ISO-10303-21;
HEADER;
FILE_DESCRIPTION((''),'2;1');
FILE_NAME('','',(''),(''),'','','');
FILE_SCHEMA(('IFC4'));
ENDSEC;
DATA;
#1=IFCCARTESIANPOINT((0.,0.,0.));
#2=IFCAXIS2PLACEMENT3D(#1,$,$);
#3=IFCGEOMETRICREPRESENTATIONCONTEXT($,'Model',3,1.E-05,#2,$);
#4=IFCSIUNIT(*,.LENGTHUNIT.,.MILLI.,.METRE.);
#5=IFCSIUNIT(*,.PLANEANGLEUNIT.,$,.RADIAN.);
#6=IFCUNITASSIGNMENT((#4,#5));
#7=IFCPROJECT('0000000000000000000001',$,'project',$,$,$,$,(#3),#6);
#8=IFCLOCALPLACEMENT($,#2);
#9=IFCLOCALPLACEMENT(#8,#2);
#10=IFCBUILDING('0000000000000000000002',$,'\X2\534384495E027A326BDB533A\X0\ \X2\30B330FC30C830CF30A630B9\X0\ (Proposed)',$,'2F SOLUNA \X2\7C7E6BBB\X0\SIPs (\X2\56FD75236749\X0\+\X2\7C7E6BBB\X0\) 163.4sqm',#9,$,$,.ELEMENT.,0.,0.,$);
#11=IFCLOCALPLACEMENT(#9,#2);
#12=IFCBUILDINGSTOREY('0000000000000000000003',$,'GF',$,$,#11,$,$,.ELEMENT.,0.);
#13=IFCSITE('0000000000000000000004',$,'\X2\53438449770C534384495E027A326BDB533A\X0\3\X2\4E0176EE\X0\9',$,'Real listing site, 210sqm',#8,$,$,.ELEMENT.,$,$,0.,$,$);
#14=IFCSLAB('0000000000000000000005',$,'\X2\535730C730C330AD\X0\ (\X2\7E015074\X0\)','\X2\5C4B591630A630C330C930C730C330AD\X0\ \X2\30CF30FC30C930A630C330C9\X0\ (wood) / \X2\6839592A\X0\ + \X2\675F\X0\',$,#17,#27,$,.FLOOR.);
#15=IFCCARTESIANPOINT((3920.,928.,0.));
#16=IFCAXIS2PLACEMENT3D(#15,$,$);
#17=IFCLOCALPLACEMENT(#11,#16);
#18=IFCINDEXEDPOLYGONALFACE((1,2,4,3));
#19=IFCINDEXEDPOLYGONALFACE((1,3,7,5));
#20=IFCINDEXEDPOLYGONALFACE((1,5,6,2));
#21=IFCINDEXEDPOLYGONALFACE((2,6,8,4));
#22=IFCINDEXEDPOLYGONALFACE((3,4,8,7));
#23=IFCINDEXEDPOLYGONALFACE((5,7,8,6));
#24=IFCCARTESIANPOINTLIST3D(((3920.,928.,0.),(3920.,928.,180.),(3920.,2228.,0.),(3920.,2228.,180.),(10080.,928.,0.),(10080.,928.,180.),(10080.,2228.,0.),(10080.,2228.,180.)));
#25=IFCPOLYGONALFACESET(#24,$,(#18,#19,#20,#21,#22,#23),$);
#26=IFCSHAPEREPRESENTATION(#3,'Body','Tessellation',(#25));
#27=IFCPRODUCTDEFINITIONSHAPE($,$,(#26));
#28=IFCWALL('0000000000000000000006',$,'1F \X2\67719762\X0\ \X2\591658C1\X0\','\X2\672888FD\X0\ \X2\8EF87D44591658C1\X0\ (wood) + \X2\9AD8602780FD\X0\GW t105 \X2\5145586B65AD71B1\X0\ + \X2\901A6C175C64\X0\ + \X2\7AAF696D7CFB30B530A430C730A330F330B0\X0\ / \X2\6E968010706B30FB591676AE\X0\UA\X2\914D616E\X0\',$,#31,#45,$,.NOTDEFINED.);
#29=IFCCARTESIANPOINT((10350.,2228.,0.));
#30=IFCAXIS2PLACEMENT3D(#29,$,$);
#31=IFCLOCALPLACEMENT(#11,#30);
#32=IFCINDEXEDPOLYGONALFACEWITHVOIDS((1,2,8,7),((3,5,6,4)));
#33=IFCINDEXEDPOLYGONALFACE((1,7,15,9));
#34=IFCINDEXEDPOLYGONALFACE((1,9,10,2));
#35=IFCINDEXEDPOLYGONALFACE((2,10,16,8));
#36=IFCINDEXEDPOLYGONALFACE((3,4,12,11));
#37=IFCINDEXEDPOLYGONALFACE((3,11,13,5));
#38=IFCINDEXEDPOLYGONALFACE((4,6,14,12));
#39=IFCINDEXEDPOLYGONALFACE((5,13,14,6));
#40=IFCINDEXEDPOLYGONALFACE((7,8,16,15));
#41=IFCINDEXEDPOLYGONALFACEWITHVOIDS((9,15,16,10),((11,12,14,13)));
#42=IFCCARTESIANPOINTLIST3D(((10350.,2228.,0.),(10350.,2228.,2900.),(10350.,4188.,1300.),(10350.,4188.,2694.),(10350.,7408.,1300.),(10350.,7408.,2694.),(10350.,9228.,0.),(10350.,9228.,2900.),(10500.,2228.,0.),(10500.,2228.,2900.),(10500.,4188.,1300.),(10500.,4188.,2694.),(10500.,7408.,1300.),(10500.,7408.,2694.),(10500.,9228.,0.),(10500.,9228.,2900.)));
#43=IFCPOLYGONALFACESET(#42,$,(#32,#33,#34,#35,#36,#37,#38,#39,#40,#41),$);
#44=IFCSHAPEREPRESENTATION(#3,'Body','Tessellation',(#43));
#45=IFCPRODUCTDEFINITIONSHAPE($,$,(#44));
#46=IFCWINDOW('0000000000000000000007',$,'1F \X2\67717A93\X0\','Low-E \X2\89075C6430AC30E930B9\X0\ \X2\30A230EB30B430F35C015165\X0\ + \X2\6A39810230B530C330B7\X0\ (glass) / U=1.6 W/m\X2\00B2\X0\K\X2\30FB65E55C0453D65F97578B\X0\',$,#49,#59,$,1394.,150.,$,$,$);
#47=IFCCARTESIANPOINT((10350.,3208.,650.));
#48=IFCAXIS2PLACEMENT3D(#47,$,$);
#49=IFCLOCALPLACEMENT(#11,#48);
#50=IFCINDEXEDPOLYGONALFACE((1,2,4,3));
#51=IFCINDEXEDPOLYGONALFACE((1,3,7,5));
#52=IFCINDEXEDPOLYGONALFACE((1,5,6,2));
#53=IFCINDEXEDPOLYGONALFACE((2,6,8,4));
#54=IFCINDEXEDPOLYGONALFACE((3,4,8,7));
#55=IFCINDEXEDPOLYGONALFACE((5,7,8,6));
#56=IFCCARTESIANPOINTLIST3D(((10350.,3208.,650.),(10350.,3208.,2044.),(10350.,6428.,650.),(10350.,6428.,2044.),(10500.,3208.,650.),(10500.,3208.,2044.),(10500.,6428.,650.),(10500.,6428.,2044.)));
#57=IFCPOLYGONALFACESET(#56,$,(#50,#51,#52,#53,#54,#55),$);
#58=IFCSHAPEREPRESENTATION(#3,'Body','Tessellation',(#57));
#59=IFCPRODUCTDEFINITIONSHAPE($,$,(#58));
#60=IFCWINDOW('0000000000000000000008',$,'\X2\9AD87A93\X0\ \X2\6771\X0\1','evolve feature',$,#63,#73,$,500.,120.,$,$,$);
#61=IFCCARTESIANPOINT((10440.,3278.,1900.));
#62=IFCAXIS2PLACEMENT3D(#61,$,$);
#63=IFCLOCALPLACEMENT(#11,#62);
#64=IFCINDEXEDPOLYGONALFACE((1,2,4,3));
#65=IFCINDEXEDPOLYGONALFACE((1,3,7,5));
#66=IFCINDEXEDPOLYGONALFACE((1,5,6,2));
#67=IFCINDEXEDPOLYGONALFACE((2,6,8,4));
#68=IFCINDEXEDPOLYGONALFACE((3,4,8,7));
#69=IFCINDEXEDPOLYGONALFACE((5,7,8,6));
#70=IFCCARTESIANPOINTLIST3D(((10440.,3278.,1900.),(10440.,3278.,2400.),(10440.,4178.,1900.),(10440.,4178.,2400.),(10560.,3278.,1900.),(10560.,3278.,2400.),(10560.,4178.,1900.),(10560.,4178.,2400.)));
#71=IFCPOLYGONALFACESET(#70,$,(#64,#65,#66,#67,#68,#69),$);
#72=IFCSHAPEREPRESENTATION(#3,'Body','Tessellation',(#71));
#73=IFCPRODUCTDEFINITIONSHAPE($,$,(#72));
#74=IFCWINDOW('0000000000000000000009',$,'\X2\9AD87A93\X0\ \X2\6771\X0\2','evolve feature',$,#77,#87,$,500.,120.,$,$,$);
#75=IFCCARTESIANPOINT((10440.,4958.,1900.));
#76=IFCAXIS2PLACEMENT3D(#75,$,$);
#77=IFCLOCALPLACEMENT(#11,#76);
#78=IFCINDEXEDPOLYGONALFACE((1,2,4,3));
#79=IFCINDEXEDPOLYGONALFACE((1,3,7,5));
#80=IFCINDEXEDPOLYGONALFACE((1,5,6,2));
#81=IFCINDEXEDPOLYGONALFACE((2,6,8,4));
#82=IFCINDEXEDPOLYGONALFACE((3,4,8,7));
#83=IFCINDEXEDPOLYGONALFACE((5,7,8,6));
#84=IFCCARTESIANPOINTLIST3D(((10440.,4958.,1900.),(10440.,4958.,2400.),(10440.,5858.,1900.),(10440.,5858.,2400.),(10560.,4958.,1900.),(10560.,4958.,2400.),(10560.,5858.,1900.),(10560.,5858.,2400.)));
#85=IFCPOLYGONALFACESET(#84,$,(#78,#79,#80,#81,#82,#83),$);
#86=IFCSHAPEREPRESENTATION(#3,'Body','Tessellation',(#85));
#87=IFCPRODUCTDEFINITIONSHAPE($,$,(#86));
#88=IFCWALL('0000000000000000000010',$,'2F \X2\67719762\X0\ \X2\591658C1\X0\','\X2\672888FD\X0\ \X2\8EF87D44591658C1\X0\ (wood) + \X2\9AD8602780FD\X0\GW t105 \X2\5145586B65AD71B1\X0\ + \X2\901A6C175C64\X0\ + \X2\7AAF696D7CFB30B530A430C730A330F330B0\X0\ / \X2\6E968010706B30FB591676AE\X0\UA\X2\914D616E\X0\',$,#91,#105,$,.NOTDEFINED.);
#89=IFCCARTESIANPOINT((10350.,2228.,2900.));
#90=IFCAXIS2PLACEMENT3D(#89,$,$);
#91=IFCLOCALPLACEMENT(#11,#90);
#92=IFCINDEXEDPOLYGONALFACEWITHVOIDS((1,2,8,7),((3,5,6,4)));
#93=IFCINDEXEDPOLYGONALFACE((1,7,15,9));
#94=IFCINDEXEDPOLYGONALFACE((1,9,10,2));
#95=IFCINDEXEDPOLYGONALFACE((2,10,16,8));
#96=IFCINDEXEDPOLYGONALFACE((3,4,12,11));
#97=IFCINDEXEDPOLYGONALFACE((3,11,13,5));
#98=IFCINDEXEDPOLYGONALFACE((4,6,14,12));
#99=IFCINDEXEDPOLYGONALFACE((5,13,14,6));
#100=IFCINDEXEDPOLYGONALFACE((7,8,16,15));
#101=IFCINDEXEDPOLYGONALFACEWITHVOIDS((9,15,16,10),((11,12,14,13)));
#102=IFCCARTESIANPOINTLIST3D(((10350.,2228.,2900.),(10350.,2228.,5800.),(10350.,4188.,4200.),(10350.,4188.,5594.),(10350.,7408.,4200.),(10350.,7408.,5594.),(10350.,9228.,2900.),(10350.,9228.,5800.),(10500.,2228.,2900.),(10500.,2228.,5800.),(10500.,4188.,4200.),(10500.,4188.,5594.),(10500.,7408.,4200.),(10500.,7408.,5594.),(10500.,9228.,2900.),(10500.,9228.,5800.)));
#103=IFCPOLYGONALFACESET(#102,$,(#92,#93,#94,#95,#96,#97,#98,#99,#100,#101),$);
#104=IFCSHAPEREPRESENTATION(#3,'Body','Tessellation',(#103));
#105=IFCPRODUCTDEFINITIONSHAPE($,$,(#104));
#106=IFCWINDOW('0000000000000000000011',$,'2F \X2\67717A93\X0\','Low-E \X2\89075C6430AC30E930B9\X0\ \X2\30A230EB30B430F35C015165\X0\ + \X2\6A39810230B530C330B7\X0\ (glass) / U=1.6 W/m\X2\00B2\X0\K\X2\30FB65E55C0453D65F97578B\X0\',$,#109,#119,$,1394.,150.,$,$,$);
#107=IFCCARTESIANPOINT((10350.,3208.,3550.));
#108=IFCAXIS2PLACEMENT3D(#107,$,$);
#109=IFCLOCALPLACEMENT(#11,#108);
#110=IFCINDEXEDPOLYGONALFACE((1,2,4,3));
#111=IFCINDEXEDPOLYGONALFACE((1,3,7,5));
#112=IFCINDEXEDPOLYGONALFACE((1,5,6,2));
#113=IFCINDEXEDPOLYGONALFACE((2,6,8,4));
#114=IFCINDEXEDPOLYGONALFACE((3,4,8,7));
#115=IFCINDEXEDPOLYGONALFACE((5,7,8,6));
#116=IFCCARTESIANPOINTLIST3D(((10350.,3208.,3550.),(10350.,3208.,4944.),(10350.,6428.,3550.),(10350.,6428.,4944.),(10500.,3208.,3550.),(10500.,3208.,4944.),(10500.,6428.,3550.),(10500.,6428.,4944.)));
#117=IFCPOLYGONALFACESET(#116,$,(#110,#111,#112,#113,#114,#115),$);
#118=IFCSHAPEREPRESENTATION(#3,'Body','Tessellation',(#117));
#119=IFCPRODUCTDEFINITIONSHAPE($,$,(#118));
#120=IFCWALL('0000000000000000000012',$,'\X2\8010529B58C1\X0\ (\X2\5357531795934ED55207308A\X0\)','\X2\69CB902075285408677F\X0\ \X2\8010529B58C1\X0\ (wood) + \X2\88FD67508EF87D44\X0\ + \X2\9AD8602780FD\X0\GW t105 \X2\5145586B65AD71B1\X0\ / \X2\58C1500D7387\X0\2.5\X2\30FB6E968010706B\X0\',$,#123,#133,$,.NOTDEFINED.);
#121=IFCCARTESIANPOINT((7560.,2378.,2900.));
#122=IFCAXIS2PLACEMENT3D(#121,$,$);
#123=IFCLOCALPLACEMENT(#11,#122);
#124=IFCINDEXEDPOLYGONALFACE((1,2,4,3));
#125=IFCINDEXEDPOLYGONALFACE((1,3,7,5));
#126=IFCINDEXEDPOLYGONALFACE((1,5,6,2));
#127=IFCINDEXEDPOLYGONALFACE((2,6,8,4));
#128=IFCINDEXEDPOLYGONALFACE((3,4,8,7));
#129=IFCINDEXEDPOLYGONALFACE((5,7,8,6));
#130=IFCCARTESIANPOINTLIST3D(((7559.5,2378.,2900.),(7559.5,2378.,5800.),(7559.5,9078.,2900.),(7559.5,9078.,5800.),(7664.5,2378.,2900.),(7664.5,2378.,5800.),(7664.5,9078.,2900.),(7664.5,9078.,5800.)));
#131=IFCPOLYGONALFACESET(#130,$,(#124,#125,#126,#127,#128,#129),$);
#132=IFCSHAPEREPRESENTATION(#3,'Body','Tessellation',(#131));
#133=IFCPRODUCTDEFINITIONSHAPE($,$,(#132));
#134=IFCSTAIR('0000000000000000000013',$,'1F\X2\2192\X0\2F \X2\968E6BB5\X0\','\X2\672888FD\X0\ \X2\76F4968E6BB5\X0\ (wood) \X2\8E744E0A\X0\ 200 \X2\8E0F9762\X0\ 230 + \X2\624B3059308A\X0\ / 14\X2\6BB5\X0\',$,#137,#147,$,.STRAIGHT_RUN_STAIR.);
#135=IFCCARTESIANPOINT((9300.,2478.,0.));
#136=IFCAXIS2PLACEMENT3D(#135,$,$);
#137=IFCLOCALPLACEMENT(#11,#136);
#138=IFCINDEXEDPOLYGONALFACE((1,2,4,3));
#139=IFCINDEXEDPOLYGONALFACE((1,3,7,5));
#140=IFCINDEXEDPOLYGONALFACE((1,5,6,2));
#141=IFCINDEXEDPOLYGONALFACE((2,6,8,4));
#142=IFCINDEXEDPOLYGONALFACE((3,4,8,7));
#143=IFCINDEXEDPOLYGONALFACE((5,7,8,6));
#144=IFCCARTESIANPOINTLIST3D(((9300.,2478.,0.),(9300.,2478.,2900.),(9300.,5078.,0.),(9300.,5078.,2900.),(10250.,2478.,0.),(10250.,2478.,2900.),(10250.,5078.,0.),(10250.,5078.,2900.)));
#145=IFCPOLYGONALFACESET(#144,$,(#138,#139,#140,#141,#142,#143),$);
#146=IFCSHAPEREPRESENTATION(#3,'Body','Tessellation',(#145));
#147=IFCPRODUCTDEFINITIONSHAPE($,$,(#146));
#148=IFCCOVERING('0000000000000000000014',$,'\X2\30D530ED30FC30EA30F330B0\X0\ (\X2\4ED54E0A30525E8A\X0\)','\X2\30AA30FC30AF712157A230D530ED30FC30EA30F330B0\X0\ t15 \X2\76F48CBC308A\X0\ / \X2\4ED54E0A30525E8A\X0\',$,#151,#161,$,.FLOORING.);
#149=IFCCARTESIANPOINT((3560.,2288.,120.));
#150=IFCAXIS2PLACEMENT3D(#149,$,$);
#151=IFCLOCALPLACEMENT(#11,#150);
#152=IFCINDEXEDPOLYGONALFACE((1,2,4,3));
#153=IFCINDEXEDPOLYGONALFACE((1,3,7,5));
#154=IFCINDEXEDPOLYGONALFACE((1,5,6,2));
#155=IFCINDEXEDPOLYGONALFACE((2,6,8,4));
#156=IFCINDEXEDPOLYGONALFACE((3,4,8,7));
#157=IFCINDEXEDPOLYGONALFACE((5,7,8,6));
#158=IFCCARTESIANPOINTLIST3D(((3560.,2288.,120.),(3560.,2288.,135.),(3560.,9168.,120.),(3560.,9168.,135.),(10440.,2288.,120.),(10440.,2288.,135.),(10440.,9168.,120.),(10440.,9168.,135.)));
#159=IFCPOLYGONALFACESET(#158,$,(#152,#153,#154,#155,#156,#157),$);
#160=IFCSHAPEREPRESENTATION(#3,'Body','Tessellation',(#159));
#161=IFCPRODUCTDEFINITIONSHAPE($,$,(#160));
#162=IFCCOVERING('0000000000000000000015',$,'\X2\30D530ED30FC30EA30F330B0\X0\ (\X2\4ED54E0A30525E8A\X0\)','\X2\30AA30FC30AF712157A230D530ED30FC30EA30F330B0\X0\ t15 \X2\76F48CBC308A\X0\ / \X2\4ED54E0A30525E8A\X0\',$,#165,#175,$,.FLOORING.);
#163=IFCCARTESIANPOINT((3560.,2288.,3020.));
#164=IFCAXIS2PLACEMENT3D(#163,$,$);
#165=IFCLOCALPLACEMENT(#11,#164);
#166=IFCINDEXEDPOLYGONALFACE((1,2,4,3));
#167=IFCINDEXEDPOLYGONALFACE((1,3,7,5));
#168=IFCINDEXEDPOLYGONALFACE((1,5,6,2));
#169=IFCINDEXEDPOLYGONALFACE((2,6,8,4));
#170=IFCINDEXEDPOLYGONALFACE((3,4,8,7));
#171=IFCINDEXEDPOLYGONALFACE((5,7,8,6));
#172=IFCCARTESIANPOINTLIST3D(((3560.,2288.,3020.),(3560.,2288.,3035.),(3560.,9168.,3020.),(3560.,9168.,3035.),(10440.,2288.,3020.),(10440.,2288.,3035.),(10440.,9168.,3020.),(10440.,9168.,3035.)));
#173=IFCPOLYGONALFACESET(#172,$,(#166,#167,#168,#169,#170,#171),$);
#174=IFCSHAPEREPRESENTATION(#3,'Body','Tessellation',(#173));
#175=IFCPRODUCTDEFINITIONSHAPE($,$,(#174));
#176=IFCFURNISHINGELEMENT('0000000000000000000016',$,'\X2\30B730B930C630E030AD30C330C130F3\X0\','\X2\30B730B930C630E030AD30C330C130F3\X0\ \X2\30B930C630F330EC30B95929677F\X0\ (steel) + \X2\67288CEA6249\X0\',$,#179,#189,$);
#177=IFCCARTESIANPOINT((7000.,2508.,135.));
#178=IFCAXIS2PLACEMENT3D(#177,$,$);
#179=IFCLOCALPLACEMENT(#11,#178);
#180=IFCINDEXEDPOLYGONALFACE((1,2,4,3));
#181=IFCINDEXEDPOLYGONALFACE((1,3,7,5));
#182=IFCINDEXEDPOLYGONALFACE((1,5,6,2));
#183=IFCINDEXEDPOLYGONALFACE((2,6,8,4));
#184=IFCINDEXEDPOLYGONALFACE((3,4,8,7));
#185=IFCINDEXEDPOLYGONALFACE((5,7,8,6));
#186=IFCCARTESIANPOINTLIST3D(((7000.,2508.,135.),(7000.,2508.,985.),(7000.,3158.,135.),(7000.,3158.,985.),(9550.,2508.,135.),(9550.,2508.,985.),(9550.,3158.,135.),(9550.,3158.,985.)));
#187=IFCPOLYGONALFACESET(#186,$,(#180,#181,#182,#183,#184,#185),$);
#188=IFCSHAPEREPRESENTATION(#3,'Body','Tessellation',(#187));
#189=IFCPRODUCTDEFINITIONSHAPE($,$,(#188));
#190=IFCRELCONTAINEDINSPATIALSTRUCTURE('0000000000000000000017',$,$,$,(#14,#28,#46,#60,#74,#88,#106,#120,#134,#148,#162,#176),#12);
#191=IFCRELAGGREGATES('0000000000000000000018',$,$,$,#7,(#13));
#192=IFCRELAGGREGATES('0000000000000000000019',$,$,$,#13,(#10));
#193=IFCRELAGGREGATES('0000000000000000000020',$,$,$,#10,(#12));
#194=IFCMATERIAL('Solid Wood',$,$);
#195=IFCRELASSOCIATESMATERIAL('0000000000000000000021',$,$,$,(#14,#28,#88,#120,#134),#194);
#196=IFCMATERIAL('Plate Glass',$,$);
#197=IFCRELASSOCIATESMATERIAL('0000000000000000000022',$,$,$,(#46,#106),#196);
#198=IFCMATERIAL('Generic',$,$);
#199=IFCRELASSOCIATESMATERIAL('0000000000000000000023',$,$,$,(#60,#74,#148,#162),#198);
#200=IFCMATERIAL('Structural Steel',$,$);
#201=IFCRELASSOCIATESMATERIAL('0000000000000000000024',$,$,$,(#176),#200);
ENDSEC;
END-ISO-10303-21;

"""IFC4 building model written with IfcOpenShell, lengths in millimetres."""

from ifc_helpers import new_model, si_unit, frame, frame_2d, origin, place, context, project, spatial, rectangle, extrude, material, element, fill, save


model = new_model("IFC4")

# Units and contexts
model_context = context("Model", 3, precision=1e-05, world=origin())
ifc_project = project(units=[si_unit("LENGTHUNIT", "METRE", prefix="MILLI"), si_unit("PLANEANGLEUNIT", "RADIAN")], contexts=[model_context])

# Site, building, storey
site_placement = place(None, origin())
site = spatial("IfcSite", under=ifc_project, at=site_placement, Name="千葉県千葉市稲毛区3丁目9", ObjectType="Real listing site, 210sqm", CompositionType="ELEMENT", RefElevation=0.0)
building_placement = place(site_placement, origin())
building = spatial("IfcBuilding", under=site, at=building_placement, Name="千葉市稲毛区 コートハウス (Proposed)", ObjectType="2F SOLUNA 籾殻SIPs (国産杉+籾殻) 163.4sqm", CompositionType="ELEMENT", ElevationOfRefHeight=0.0, ElevationOfTerrain=0.0)
storey_placement = place(building_placement, origin())
storey = spatial("IfcBuildingStorey", under=building, at=storey_placement, Name="GF", CompositionType="ELEMENT", Elevation=0.0)

# Slab
ifc_material_1 = material(Name="Solid Wood")
slab_placement = place(storey_placement, frame((3920.0, 928.0, 0.0)))
element("IfcSlab", 1, at=slab_placement, inside=storey, material=ifc_material_1, Name="南デッキ (縁側)", Description="屋外ウッドデッキ ハードウッド (wood) / 根太 + 束", PredefinedType="FLOOR", context=model_context, shape_type="SweptSolid", body=[
    extrude(rectangle(XDim=6160.0, YDim=1300.0, at=frame_2d((3080.0, 650.0))), frame((3920.0, 928.0, 0.0)), (0.0, 0.0, 1.0), 180.0),
])

# Wall, openings, windows
wall_1_placement = place(storey_placement, frame((10350.0, 2228.0, 0.0)))
wall_1 = element("IfcWall", 2, at=wall_1_placement, inside=storey, material=ifc_material_1, Name="1F 東面 外壁", Description="木製 軸組外壁 (wood) + 高性能GW t105 充填断熱 + 通気層 + 窯業系サイディング / 準耐火・外皮UA配慮", PredefinedType="NOTDEFINED", context=model_context, shape_type="SweptSolid", body=[
    extrude(rectangle(XDim=150.0, YDim=7000.0, at=frame_2d((75.0, 3500.0))), frame((10350.0, 2228.0, 0.0)), (0.0, 0.0, 1.0), 2900.0),
])
opening_1_placement = place(storey_placement, frame((10350.0, 3208.0, 650.0)))
opening_1 = element("IfcOpeningElement", 3, at=opening_1_placement, cuts=wall_1, PredefinedType="NOTDEFINED", context=model_context, shape_type="SweptSolid", body=[
    extrude(rectangle(XDim=150.0, YDim=3220.0, at=frame_2d((75.0, 1610.0))), frame((10350.0, 3208.0, 650.0)), (0.0, 0.0, 1.0), 1394.0),
])
opening_2_placement = place(storey_placement, frame((10440.0, 3278.0, 1900.0)))
opening_2 = element("IfcOpeningElement", 4, at=opening_2_placement, cuts=wall_1, PredefinedType="NOTDEFINED", context=model_context, shape_type="SweptSolid", body=[
    extrude(rectangle(XDim=120.0, YDim=900.0, at=frame_2d((60.0, 450.0))), frame((10440.0, 3278.0, 1900.0)), (0.0, 0.0, 1.0), 500.0),
])
opening_3_placement = place(storey_placement, frame((10440.0, 4958.0, 1900.0)))
opening_3 = element("IfcOpeningElement", 5, at=opening_3_placement, cuts=wall_1, PredefinedType="NOTDEFINED", context=model_context, shape_type="SweptSolid", body=[
    extrude(rectangle(XDim=120.0, YDim=900.0, at=frame_2d((60.0, 450.0))), frame((10440.0, 4958.0, 1900.0)), (0.0, 0.0, 1.0), 500.0),
])
ifc_material_2 = material(Name="Plate Glass")
window_1_placement = place(storey_placement, frame((10350.0, 3208.0, 650.0)))
window_1 = element("IfcWindow", 6, at=window_1_placement, inside=storey, material=ifc_material_2, Name="1F 東窓", Description="Low-E 複層ガラス アルゴン封入 + 樹脂サッシ (glass) / U=1.6 W/m²K・日射取得型", OverallHeight=1394.0, OverallWidth=150.0, context=model_context, shape_type="SweptSolid", body=[
    extrude(rectangle(XDim=150.0, YDim=3220.0, at=frame_2d((75.0, 1610.0))), frame((10350.0, 3208.0, 650.0)), (0.0, 0.0, 1.0), 1394.0),
])
fill(opening_1, window_1)
ifc_material_3 = material(Name="Generic")
window_2_placement = place(storey_placement, frame((10440.0, 3278.0, 1900.0)))
window_2 = element("IfcWindow", 7, at=window_2_placement, inside=storey, material=ifc_material_3, Name="高窓 東1", Description="evolve feature", OverallHeight=500.0, OverallWidth=120.0, context=model_context, shape_type="SweptSolid", body=[
    extrude(rectangle(XDim=120.0, YDim=900.0, at=frame_2d((60.0, 450.0))), frame((10440.0, 3278.0, 1900.0)), (0.0, 0.0, 1.0), 500.0),
])
fill(opening_2, window_2)
window_3_placement = place(storey_placement, frame((10440.0, 4958.0, 1900.0)))
window_3 = element("IfcWindow", 8, at=window_3_placement, inside=storey, material=ifc_material_3, Name="高窓 東2", Description="evolve feature", OverallHeight=500.0, OverallWidth=120.0, context=model_context, shape_type="SweptSolid", body=[
    extrude(rectangle(XDim=120.0, YDim=900.0, at=frame_2d((60.0, 450.0))), frame((10440.0, 4958.0, 1900.0)), (0.0, 0.0, 1.0), 500.0),
])
fill(opening_3, window_3)

# Wall, opening, window
wall_2_placement = place(storey_placement, frame((10350.0, 2228.0, 2900.0)))
wall_2 = element("IfcWall", 9, at=wall_2_placement, inside=storey, material=ifc_material_1, Name="2F 東面 外壁", Description="木製 軸組外壁 (wood) + 高性能GW t105 充填断熱 + 通気層 + 窯業系サイディング / 準耐火・外皮UA配慮", PredefinedType="NOTDEFINED", context=model_context, shape_type="SweptSolid", body=[
    extrude(rectangle(XDim=150.0, YDim=7000.0, at=frame_2d((75.0, 3500.0))), frame((10350.0, 2228.0, 2900.0)), (0.0, 0.0, 1.0), 2900.0),
])
opening_4_placement = place(storey_placement, frame((10350.0, 3208.0, 3550.0)))
opening_4 = element("IfcOpeningElement", 10, at=opening_4_placement, cuts=wall_2, PredefinedType="NOTDEFINED", context=model_context, shape_type="SweptSolid", body=[
    extrude(rectangle(XDim=150.0, YDim=3220.0, at=frame_2d((75.0, 1610.0))), frame((10350.0, 3208.0, 3550.0)), (0.0, 0.0, 1.0), 1394.0),
])
window_4_placement = place(storey_placement, frame((10350.0, 3208.0, 3550.0)))
window_4 = element("IfcWindow", 11, at=window_4_placement, inside=storey, material=ifc_material_2, Name="2F 東窓", Description="Low-E 複層ガラス アルゴン封入 + 樹脂サッシ (glass) / U=1.6 W/m²K・日射取得型", OverallHeight=1394.0, OverallWidth=150.0, context=model_context, shape_type="SweptSolid", body=[
    extrude(rectangle(XDim=150.0, YDim=3220.0, at=frame_2d((75.0, 1610.0))), frame((10350.0, 3208.0, 3550.0)), (0.0, 0.0, 1.0), 1394.0),
])
fill(opening_4, window_4)

# Wall
wall_3_placement = place(storey_placement, frame((7560.0, 2378.0, 2900.0)))
element("IfcWall", 12, at=wall_3_placement, inside=storey, material=ifc_material_1, Name="耐力壁 (南北間仕切り)", Description="構造用合板 耐力壁 (wood) + 製材軸組 + 高性能GW t105 充填断熱 / 壁倍率2.5・準耐火", PredefinedType="NOTDEFINED", context=model_context, shape_type="SweptSolid", body=[
    extrude(rectangle(XDim=105.0, YDim=6700.0, at=frame_2d((52.0, 3350.0))), frame((7560.0, 2378.0, 2900.0)), (0.0, 0.0, 1.0), 2900.0),
])

# Stair
stair_placement = place(storey_placement, frame((9300.0, 2478.0, 0.0)))
element("IfcStair", 13, at=stair_placement, inside=storey, material=ifc_material_1, Name="1F→2F 階段", Description="木製 直階段 (wood) 蹴上 200 踏面 230 + 手すり / 14段", PredefinedType="STRAIGHT_RUN_STAIR", context=model_context, shape_type="SweptSolid", body=[
    extrude(rectangle(XDim=950.0, YDim=2600.0, at=frame_2d((475.0, 1300.0))), frame((9300.0, 2478.0, 0.0)), (0.0, 0.0, 1.0), 2900.0),
])

# Coverings
covering_1_placement = place(storey_placement, frame((3560.0, 2288.0, 120.0)))
element("IfcCovering", 14, at=covering_1_placement, inside=storey, material=ifc_material_3, Name="フローリング (仕上げ床)", Description="オーク無垢フローリング t15 直貼り / 仕上げ床", PredefinedType="FLOORING", context=model_context, shape_type="SweptSolid", body=[
    extrude(rectangle(XDim=6880.0, YDim=6880.0, at=frame_2d((3440.0, 3440.0))), frame((3560.0, 2288.0, 120.0)), (0.0, 0.0, 1.0), 15.0),
])
covering_2_placement = place(storey_placement, frame((3560.0, 2288.0, 3020.0)))
element("IfcCovering", 15, at=covering_2_placement, inside=storey, material=ifc_material_3, Name="フローリング (仕上げ床)", Description="オーク無垢フローリング t15 直貼り / 仕上げ床", PredefinedType="FLOORING", context=model_context, shape_type="SweptSolid", body=[
    extrude(rectangle(XDim=6880.0, YDim=6880.0, at=frame_2d((3440.0, 3440.0))), frame((3560.0, 2288.0, 3020.0)), (0.0, 0.0, 1.0), 15.0),
])

# Furnishing element
ifc_material_4 = material(Name="Structural Steel")
furnishing_1_placement = place(storey_placement, frame((7000.0, 2508.0, 135.0)))
element("IfcFurnishingElement", 16, at=furnishing_1_placement, inside=storey, material=ifc_material_4, Name="システムキッチン", Description="システムキッチン ステンレス天板 (steel) + 木質扉", context=model_context, shape_type="SweptSolid", body=[
    extrude(rectangle(XDim=2550.0, YDim=650.0, at=frame_2d((1275.0, 325.0))), frame((7000.0, 2508.0, 135.0)), (0.0, 0.0, 1.0), 850.0),
])

save(model, "model.ifc")
